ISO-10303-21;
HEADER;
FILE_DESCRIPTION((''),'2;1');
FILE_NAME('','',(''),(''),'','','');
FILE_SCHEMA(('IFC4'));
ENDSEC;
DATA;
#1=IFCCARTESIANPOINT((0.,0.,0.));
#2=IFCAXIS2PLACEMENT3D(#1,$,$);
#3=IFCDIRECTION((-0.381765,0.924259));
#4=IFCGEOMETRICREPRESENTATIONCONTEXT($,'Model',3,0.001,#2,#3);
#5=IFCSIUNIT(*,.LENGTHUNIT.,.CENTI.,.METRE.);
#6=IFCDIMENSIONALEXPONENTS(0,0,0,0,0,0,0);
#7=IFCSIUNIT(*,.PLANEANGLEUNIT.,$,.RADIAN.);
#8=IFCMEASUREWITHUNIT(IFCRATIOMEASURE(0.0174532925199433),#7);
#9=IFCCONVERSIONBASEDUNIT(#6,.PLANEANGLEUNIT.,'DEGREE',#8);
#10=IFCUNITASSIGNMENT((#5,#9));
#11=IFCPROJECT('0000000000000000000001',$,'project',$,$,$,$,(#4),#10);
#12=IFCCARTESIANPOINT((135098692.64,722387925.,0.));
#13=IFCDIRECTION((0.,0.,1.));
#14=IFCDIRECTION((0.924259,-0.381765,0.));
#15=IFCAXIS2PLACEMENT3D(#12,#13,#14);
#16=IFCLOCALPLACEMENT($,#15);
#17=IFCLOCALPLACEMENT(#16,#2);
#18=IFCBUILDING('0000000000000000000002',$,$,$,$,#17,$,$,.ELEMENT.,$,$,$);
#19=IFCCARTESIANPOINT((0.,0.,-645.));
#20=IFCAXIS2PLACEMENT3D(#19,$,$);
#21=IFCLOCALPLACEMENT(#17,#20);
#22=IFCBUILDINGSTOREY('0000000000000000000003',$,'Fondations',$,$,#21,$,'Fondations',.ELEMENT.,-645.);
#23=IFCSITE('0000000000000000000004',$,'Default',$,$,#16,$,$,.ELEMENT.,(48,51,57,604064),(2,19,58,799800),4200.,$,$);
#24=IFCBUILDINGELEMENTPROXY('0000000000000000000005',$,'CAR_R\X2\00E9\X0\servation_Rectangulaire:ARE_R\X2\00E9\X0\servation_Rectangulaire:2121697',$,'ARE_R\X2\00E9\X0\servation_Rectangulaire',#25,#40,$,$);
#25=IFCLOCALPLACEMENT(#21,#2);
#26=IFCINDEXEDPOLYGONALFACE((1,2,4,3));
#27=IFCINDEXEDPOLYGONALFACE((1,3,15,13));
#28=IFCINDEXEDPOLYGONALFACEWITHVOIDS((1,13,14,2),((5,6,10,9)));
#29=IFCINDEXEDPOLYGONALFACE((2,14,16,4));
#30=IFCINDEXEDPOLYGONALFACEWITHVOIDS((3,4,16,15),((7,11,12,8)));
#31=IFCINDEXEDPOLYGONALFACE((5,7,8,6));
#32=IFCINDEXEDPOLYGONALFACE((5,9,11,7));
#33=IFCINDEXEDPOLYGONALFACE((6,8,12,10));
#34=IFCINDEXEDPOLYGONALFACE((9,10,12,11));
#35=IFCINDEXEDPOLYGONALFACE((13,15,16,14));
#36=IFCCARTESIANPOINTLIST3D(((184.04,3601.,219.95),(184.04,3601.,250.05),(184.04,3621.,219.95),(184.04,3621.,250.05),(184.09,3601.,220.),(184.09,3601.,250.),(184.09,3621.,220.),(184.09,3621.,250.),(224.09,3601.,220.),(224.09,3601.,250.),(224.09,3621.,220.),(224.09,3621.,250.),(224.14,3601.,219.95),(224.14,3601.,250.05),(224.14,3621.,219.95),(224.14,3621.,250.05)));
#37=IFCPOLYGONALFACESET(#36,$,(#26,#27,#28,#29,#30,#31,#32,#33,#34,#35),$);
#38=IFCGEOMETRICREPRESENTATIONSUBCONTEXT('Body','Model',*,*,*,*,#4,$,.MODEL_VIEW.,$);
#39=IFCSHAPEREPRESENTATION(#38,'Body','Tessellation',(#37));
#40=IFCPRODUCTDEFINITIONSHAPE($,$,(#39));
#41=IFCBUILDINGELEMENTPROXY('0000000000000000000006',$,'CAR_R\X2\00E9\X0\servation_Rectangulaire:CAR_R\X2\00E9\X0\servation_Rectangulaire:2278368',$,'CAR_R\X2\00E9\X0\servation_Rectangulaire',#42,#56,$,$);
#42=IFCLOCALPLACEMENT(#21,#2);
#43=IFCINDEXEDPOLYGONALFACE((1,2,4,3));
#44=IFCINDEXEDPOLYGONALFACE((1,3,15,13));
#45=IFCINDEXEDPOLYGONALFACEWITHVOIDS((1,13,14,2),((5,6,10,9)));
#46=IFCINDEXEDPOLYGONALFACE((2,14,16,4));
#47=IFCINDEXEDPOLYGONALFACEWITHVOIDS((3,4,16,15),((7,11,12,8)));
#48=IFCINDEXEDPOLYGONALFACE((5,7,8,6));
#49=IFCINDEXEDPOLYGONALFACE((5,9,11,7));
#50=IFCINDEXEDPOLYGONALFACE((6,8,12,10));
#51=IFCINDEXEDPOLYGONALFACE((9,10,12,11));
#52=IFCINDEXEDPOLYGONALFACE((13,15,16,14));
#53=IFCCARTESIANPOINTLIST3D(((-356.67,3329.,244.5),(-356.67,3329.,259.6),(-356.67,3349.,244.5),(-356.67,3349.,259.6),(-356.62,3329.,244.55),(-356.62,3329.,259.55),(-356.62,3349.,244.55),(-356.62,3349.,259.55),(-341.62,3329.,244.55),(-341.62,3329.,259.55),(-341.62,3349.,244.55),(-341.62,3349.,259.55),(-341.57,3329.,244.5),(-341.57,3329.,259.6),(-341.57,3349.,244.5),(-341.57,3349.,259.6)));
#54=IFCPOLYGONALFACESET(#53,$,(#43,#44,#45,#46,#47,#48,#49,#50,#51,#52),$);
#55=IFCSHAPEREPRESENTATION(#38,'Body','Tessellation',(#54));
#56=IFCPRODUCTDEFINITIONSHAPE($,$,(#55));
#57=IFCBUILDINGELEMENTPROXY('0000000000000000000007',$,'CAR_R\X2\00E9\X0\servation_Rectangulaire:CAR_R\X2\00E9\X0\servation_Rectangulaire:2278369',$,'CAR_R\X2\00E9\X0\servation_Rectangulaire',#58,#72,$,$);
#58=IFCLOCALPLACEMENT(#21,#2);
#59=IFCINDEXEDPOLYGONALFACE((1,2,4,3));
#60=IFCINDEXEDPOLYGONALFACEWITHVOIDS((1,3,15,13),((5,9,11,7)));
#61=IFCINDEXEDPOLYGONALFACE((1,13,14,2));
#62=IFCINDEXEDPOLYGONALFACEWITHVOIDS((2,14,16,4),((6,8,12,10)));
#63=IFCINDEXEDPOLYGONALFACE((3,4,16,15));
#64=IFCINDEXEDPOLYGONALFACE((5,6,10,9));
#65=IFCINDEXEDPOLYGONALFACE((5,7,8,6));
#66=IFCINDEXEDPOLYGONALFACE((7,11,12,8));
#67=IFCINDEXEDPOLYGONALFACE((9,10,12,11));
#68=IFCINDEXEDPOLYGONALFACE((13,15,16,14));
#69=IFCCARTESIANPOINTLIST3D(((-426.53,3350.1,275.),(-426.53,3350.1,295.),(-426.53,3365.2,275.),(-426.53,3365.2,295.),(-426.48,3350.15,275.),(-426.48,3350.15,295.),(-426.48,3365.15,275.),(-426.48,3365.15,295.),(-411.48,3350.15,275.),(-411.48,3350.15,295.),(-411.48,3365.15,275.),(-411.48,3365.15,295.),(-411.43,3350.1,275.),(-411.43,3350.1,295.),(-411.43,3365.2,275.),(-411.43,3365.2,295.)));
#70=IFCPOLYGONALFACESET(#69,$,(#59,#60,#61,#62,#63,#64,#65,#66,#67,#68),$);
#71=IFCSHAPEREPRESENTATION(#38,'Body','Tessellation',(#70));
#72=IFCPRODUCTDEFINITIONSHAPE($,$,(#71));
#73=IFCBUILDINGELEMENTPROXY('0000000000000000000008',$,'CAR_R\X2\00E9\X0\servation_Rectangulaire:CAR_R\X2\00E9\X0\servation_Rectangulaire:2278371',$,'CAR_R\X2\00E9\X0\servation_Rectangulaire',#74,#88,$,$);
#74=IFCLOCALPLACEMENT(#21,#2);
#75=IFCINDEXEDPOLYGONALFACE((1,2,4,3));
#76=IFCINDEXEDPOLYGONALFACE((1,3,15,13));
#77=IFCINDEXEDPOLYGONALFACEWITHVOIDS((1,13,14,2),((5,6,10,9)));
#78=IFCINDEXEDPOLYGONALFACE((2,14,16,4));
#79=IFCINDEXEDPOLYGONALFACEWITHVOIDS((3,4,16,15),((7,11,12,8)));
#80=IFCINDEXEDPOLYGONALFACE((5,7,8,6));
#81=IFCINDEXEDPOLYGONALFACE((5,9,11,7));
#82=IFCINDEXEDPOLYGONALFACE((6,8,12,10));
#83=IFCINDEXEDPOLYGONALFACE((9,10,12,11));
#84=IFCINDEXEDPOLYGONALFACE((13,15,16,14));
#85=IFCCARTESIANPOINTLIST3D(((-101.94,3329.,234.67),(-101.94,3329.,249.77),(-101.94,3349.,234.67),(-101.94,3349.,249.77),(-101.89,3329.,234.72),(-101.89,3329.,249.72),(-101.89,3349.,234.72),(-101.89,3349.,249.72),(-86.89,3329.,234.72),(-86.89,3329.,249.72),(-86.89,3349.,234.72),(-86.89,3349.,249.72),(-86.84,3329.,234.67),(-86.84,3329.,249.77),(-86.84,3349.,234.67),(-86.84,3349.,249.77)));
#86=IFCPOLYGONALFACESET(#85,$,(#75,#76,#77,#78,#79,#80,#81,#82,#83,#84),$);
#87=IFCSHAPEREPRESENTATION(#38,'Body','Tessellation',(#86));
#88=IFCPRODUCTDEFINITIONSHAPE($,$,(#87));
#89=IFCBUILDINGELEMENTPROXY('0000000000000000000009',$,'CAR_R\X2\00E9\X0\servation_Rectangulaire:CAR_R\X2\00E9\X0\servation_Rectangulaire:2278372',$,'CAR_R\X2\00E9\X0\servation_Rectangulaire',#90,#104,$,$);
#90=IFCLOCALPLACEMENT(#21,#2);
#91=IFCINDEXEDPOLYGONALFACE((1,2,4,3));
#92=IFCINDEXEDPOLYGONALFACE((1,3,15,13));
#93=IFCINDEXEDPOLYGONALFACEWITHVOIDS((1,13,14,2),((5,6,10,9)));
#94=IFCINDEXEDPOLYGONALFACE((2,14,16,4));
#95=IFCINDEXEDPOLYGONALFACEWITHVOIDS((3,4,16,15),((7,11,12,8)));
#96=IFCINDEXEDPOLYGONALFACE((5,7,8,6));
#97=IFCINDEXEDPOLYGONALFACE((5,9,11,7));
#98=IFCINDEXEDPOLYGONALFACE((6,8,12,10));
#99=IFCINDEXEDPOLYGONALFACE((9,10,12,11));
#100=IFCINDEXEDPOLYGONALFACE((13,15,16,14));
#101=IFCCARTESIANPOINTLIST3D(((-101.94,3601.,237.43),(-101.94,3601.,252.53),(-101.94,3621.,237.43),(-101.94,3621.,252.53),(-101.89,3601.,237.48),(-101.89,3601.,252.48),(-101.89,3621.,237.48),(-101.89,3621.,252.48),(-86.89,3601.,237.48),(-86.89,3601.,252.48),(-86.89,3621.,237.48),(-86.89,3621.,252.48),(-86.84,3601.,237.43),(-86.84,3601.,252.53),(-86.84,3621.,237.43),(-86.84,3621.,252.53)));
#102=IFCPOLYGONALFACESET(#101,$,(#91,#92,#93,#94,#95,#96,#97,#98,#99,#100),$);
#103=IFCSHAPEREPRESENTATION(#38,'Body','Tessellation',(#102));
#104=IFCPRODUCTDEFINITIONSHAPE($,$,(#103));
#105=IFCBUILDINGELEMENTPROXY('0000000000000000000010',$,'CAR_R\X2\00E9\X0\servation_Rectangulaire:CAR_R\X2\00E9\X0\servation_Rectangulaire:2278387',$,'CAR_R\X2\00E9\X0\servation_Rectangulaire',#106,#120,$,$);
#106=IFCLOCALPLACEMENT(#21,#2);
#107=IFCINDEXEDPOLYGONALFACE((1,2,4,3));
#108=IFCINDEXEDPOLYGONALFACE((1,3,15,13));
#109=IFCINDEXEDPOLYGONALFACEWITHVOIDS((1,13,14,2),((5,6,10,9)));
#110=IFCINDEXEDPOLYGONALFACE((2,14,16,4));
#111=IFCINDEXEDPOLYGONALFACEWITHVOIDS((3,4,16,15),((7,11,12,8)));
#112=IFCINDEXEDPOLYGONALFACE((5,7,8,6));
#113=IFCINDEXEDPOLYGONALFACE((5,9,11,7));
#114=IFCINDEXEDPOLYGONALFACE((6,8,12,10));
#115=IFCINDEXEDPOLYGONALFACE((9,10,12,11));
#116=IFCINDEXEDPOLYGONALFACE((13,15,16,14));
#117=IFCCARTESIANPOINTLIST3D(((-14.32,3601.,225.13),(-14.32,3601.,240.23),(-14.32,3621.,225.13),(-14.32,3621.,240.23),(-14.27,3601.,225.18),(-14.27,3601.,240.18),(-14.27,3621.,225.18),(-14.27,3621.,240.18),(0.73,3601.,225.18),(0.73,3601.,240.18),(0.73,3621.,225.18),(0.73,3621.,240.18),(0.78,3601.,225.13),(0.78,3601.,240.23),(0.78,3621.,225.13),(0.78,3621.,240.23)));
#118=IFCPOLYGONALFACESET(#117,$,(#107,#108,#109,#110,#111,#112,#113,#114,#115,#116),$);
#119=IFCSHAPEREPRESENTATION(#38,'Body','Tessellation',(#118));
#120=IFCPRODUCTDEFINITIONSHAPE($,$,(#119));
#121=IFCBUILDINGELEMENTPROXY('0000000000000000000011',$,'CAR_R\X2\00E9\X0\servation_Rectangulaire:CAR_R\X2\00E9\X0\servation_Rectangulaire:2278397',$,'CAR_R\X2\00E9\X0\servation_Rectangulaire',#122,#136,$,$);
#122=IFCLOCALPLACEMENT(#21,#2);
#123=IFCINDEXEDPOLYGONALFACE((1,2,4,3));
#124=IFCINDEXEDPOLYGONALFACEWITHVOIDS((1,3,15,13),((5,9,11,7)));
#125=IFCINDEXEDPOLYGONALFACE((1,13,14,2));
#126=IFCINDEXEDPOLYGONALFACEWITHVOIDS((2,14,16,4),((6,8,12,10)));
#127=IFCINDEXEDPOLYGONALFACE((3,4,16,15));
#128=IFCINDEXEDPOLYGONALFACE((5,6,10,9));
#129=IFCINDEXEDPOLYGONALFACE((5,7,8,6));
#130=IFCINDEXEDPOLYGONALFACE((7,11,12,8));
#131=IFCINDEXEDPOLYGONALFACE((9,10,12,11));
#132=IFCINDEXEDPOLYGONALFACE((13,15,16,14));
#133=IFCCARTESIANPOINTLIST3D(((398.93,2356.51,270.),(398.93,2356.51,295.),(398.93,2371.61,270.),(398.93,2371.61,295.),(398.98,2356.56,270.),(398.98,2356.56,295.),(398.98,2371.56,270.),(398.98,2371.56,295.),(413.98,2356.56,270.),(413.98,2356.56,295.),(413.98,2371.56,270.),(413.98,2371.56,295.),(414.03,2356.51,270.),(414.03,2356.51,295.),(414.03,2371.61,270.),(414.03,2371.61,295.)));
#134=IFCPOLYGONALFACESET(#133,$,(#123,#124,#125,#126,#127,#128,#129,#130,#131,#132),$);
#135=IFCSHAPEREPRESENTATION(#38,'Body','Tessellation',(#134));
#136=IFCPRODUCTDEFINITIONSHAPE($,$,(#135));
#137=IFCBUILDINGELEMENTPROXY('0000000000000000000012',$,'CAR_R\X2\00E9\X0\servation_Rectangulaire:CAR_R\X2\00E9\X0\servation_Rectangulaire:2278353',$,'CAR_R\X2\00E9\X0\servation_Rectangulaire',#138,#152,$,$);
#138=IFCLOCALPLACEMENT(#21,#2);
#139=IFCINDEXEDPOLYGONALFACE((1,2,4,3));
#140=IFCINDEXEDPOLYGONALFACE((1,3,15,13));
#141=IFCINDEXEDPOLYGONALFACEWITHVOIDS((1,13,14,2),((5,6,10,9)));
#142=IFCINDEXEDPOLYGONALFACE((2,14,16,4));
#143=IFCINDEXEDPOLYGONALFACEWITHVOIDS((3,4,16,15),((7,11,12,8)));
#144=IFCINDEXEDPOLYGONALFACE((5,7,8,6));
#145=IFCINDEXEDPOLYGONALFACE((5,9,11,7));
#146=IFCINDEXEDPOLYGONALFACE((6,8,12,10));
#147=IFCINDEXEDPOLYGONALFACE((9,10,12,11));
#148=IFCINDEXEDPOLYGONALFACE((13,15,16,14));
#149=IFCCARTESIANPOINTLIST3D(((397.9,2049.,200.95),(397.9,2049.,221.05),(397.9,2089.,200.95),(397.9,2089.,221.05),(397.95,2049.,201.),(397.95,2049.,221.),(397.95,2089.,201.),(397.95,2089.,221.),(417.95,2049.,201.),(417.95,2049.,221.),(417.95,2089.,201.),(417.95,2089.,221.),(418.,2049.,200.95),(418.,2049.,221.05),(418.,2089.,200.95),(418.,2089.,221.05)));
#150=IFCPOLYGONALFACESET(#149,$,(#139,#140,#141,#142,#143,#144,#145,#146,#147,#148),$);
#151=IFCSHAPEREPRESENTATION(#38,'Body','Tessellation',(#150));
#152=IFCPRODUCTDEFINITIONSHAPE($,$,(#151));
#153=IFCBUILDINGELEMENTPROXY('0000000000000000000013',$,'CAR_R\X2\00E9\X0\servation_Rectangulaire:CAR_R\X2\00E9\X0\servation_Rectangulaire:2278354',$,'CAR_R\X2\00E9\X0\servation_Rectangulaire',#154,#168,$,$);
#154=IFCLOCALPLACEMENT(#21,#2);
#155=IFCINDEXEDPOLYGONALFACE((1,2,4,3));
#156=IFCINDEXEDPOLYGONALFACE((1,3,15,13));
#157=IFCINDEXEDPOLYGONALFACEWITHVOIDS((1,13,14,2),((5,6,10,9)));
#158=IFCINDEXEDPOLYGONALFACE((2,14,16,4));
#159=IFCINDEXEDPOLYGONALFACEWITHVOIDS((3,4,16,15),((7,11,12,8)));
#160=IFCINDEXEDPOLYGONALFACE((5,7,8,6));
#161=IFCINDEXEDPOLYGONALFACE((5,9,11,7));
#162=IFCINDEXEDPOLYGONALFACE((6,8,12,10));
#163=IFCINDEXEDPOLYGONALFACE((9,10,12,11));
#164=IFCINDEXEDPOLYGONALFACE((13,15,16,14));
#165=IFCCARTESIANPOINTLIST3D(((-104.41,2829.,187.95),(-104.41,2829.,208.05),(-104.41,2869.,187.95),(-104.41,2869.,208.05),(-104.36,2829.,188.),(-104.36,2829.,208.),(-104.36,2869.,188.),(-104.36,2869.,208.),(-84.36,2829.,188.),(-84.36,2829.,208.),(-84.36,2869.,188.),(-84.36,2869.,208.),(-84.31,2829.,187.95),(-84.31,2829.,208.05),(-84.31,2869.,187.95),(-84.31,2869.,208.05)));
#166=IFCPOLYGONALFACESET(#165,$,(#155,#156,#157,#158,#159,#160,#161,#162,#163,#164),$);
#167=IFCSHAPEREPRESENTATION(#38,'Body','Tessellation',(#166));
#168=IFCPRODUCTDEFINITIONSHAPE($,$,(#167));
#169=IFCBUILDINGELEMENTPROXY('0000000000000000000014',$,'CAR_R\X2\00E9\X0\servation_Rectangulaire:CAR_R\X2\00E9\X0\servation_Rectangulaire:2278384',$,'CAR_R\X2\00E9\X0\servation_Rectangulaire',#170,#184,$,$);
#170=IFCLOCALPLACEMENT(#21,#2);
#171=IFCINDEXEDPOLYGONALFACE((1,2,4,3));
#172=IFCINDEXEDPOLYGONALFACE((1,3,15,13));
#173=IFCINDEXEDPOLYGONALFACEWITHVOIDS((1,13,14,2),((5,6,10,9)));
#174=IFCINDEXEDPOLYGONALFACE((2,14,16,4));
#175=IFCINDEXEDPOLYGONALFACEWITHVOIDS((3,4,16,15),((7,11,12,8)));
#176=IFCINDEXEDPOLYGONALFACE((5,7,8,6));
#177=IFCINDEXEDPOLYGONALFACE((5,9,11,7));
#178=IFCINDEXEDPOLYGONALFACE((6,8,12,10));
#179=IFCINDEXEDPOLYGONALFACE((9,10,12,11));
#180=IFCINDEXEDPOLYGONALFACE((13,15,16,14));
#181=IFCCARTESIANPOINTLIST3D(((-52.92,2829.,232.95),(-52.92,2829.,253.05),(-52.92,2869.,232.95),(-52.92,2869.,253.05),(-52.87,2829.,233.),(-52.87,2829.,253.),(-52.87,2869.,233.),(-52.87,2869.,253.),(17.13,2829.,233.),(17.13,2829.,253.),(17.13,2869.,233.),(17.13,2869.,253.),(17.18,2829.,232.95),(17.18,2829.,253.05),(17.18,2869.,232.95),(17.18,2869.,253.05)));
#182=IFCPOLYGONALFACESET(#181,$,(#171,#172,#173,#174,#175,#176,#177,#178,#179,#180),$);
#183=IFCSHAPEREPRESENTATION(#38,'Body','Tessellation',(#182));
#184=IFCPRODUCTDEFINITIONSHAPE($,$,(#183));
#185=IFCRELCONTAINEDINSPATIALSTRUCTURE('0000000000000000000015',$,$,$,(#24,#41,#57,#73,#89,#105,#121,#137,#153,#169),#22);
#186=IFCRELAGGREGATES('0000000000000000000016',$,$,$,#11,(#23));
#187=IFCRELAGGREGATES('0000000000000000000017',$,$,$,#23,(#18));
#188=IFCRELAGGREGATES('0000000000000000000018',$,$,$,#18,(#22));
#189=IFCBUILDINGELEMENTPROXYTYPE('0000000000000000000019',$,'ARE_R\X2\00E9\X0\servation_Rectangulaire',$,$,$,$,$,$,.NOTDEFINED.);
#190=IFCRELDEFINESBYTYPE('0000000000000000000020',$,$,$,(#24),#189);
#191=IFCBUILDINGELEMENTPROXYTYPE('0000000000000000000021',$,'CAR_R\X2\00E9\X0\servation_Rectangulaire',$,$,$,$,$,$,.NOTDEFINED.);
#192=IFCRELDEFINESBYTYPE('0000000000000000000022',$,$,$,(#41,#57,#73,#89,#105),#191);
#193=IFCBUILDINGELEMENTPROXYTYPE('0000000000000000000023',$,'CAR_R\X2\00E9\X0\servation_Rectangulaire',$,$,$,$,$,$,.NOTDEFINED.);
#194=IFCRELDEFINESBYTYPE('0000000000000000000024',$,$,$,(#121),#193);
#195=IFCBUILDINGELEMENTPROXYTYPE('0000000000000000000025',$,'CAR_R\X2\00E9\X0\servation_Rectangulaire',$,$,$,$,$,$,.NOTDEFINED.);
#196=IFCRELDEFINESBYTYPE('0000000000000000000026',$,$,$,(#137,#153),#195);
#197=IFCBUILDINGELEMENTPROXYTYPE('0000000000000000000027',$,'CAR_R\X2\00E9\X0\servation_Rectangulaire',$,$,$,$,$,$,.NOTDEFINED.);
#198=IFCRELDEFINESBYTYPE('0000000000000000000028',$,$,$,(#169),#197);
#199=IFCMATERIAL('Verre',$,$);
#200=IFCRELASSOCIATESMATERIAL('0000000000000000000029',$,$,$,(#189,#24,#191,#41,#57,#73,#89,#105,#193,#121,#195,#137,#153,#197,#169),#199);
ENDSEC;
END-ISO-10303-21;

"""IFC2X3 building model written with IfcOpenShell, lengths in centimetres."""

from ifc_helpers import new_model, entity, si_unit, converted_unit, direction, frame, origin, place, context, subcontext, project, spatial, polyline, outline, extrude, source, transform, mapped, material, type_object, type_shapes, element, save


model = new_model("IFC2X3")

# Units and contexts
model_context = context("Model", 3, precision=0.001, world=origin(), true_north=direction((-0.381765, 0.924259)))
body_context = subcontext(model_context, "Body", "Model", "MODEL_VIEW")
ifc_project = project(units=[si_unit("LENGTHUNIT", "METRE", prefix="CENTI"), converted_unit("PLANEANGLEUNIT", "DEGREE", entity("IfcRatioMeasure", 0.0174532925199433), si_unit("PLANEANGLEUNIT", "RADIAN"), dimensions=[0, 0, 0, 0, 0, 0, 0])], contexts=[model_context])

# Site, building, storey
site_placement = place(None, frame((135098692.64, 722387925.0, 0.0), z_axis=(0.0, 0.0, 1.0), x_axis=(0.924259, -0.381765, 0.0)))
site = spatial("IfcSite", under=ifc_project, at=site_placement, Name="Default", CompositionType="ELEMENT", RefLatitude=(48, 51, 57, 604064), RefLongitude=(2, 19, 58, 799800), RefElevation=4200.0)
building_placement = place(site_placement, origin())
building = spatial("IfcBuilding", under=site, at=building_placement, CompositionType="ELEMENT")
storey_placement = place(building_placement, frame((0.0, 0.0, -645.0)))
storey = spatial("IfcBuildingStorey", under=building, at=storey_placement, Name="Fondations", LongName="Fondations", CompositionType="ELEMENT", Elevation=-645.0)

# Building element proxies
ifc_material_1 = material(Name="Verre")
building_element_proxy_type_1 = type_object("IfcBuildingElementProxyType", Name="ARE_Réservation_Rectangulaire", PredefinedType="NOTDEFINED", material=ifc_material_1)
shared_shape_1 = source(origin(), body_context, "Body", "SweptSolid", [
    extrude(outline(polyline([(-20.05, -15.05), (20.05, -15.05), (20.05, 15.05), (-20.05, 15.05), (-20.05, -15.05)]), holes=[polyline([(20.0, -15.0), (-20.0, -15.0), (-20.0, 15.0), (20.0, 15.0), (20.0, -15.0)])]), frame((0.0, 0.0, -20.0), z_axis=(0.0, 0.0, 1.0), x_axis=(-1.0, 0.0, 0.0)), (0.0, 0.0, 1.0), 20.0),
])
type_shapes(building_element_proxy_type_1, [shared_shape_1])
proxy_1_placement = place(storey_placement, frame((204.09, 3621.0, 235.0), z_axis=(0.0, 1.0, 0.0), x_axis=(-1.0, 0.0, 0.0)))
element("IfcBuildingElementProxy", 1, at=proxy_1_placement, inside=storey, type_object=building_element_proxy_type_1, material=ifc_material_1, Name="CAR_Réservation_Rectangulaire:ARE_Réservation_Rectangulaire:2121697", ObjectType="ARE_Réservation_Rectangulaire", context=body_context, shape_type="MappedRepresentation", body=[
    mapped(shared_shape_1, transform((0.0, 0.0, 0.0), scale=1.0)),
])
building_element_proxy_type_2 = type_object("IfcBuildingElementProxyType", Name="CAR_Réservation_Rectangulaire", PredefinedType="NOTDEFINED", material=ifc_material_1)
shared_shape_2 = source(origin(), body_context, "Body", "SweptSolid", [
    extrude(outline(polyline([(-7.55, -7.55), (7.55, -7.55), (7.55, 7.55), (-7.55, 7.55), (-7.55, -7.55)]), holes=[polyline([(7.5, -7.5), (-7.5, -7.5), (-7.5, 7.5), (7.5, 7.5), (7.5, -7.5)])]), frame((0.0, 0.0, -20.0), z_axis=(0.0, 0.0, 1.0), x_axis=(-1.0, 0.0, 0.0)), (0.0, 0.0, 1.0), 20.0),
])
type_shapes(building_element_proxy_type_2, [shared_shape_2])
proxy_2_placement = place(storey_placement, frame((-349.12, 3349.0, 252.05), z_axis=(0.0, 1.0, 0.0), x_axis=(1.0, 0.0, 0.0)))
element("IfcBuildingElementProxy", 2, at=proxy_2_placement, inside=storey, type_object=building_element_proxy_type_2, material=ifc_material_1, Name="CAR_Réservation_Rectangulaire:CAR_Réservation_Rectangulaire:2278368", ObjectType="CAR_Réservation_Rectangulaire", context=body_context, shape_type="MappedRepresentation", body=[
    mapped(shared_shape_2, transform((0.0, 0.0, 0.0), scale=1.0)),
])
proxy_3_placement = place(storey_placement, frame((-418.98, 3357.65, 295.0)))
element("IfcBuildingElementProxy", 3, at=proxy_3_placement, inside=storey, type_object=building_element_proxy_type_2, material=ifc_material_1, Name="CAR_Réservation_Rectangulaire:CAR_Réservation_Rectangulaire:2278369", ObjectType="CAR_Réservation_Rectangulaire", context=body_context, shape_type="MappedRepresentation", body=[
    mapped(shared_shape_2, transform((0.0, 0.0, 0.0), scale=1.0)),
])
for number, where, z_axis, x_axis, name in (
    (4, (-94.39, 3349.0, 242.22), (0.0, 1.0, 0.0), (1.0, 0.0, 0.0), "CAR_Réservation_Rectangulaire:CAR_Réservation_Rectangulaire:2278371"),
    (5, (-94.39, 3621.0, 244.98), (0.0, 1.0, 0.0), (-1.0, 0.0, 0.0), "CAR_Réservation_Rectangulaire:CAR_Réservation_Rectangulaire:2278372"),
    (6, (-6.77, 3621.0, 232.68), (0.0, 1.0, 0.0), (-1.0, 0.0, 0.0), "CAR_Réservation_Rectangulaire:CAR_Réservation_Rectangulaire:2278387"),
):
    element("IfcBuildingElementProxy", number, at=place(storey_placement, frame(where, z_axis=z_axis, x_axis=x_axis)), inside=storey, type_object=building_element_proxy_type_2, material=ifc_material_1, Name=name, ObjectType="CAR_Réservation_Rectangulaire", context=body_context, shape_type="MappedRepresentation", body=[
        mapped(shared_shape_2, transform((0.0, 0.0, 0.0), scale=1.0)),
    ])
building_element_proxy_type_3 = type_object("IfcBuildingElementProxyType", Name="CAR_Réservation_Rectangulaire", PredefinedType="NOTDEFINED", material=ifc_material_1)
shared_shape_3 = source(origin(), body_context, "Body", "SweptSolid", [
    extrude(outline(polyline([(-7.55, -7.55), (7.55, -7.55), (7.55, 7.55), (-7.55, 7.55), (-7.55, -7.55)]), holes=[polyline([(7.5, -7.5), (-7.5, -7.5), (-7.5, 7.5), (7.5, 7.5), (7.5, -7.5)])]), frame((0.0, 0.0, -25.0), z_axis=(0.0, 0.0, 1.0), x_axis=(-1.0, 0.0, 0.0)), (0.0, 0.0, 1.0), 25.0),
])
type_shapes(building_element_proxy_type_3, [shared_shape_3])
proxy_4_placement = place(storey_placement, frame((406.48, 2364.06, 295.0)))
element("IfcBuildingElementProxy", 7, at=proxy_4_placement, inside=storey, type_object=building_element_proxy_type_3, material=ifc_material_1, Name="CAR_Réservation_Rectangulaire:CAR_Réservation_Rectangulaire:2278397", ObjectType="CAR_Réservation_Rectangulaire", context=body_context, shape_type="MappedRepresentation", body=[
    mapped(shared_shape_3, transform((0.0, 0.0, 0.0), scale=1.0)),
])
building_element_proxy_type_4 = type_object("IfcBuildingElementProxyType", Name="CAR_Réservation_Rectangulaire", PredefinedType="NOTDEFINED", material=ifc_material_1)
shared_shape_4 = source(origin(), body_context, "Body", "SweptSolid", [
    extrude(outline(polyline([(-10.05, -10.05), (10.05, -10.05), (10.05, 10.05), (-10.05, 10.05), (-10.05, -10.05)]), holes=[polyline([(10.0, -10.0), (-10.0, -10.0), (-10.0, 10.0), (10.0, 10.0), (10.0, -10.0)])]), frame((0.0, 0.0, -40.0), z_axis=(0.0, 0.0, 1.0), x_axis=(-1.0, 0.0, 0.0)), (0.0, 0.0, 1.0), 40.0),
])
type_shapes(building_element_proxy_type_4, [shared_shape_4])
for number, where, z_axis, x_axis, name in (
    (8, (407.95, 2049.0, 211.0), (0.0, -1.0, 0.0), (1.0, 0.0, 0.0), "CAR_Réservation_Rectangulaire:CAR_Réservation_Rectangulaire:2278353"),
    (9, (-94.36, 2869.0, 198.0), (0.0, 1.0, 0.0), (-1.0, 0.0, 0.0), "CAR_Réservation_Rectangulaire:CAR_Réservation_Rectangulaire:2278354"),
):
    element("IfcBuildingElementProxy", number, at=place(storey_placement, frame(where, z_axis=z_axis, x_axis=x_axis)), inside=storey, type_object=building_element_proxy_type_4, material=ifc_material_1, Name=name, ObjectType="CAR_Réservation_Rectangulaire", context=body_context, shape_type="MappedRepresentation", body=[
        mapped(shared_shape_4, transform((0.0, 0.0, 0.0), scale=1.0)),
    ])
building_element_proxy_type_5 = type_object("IfcBuildingElementProxyType", Name="CAR_Réservation_Rectangulaire", PredefinedType="NOTDEFINED", material=ifc_material_1)
shared_shape_5 = source(origin(), body_context, "Body", "SweptSolid", [
    extrude(outline(polyline([(-35.05, -10.05), (35.05, -10.05), (35.05, 10.05), (-35.05, 10.05), (-35.05, -10.05)]), holes=[polyline([(35.0, -10.0), (-35.0, -10.0), (-35.0, 10.0), (35.0, 10.0), (35.0, -10.0)])]), frame((0.0, 0.0, -40.0), z_axis=(0.0, 0.0, 1.0), x_axis=(-1.0, 0.0, 0.0)), (0.0, 0.0, 1.0), 40.0),
])
type_shapes(building_element_proxy_type_5, [shared_shape_5])
proxy_5_placement = place(storey_placement, frame((-17.87, 2869.0, 243.0), z_axis=(0.0, 1.0, 0.0), x_axis=(-1.0, 0.0, 0.0)))
element("IfcBuildingElementProxy", 10, at=proxy_5_placement, inside=storey, type_object=building_element_proxy_type_5, material=ifc_material_1, Name="CAR_Réservation_Rectangulaire:CAR_Réservation_Rectangulaire:2278384", ObjectType="CAR_Réservation_Rectangulaire", context=body_context, shape_type="MappedRepresentation", body=[
    mapped(shared_shape_5, transform((0.0, 0.0, 0.0), scale=1.0)),
])

save(model, "model.ifc")
